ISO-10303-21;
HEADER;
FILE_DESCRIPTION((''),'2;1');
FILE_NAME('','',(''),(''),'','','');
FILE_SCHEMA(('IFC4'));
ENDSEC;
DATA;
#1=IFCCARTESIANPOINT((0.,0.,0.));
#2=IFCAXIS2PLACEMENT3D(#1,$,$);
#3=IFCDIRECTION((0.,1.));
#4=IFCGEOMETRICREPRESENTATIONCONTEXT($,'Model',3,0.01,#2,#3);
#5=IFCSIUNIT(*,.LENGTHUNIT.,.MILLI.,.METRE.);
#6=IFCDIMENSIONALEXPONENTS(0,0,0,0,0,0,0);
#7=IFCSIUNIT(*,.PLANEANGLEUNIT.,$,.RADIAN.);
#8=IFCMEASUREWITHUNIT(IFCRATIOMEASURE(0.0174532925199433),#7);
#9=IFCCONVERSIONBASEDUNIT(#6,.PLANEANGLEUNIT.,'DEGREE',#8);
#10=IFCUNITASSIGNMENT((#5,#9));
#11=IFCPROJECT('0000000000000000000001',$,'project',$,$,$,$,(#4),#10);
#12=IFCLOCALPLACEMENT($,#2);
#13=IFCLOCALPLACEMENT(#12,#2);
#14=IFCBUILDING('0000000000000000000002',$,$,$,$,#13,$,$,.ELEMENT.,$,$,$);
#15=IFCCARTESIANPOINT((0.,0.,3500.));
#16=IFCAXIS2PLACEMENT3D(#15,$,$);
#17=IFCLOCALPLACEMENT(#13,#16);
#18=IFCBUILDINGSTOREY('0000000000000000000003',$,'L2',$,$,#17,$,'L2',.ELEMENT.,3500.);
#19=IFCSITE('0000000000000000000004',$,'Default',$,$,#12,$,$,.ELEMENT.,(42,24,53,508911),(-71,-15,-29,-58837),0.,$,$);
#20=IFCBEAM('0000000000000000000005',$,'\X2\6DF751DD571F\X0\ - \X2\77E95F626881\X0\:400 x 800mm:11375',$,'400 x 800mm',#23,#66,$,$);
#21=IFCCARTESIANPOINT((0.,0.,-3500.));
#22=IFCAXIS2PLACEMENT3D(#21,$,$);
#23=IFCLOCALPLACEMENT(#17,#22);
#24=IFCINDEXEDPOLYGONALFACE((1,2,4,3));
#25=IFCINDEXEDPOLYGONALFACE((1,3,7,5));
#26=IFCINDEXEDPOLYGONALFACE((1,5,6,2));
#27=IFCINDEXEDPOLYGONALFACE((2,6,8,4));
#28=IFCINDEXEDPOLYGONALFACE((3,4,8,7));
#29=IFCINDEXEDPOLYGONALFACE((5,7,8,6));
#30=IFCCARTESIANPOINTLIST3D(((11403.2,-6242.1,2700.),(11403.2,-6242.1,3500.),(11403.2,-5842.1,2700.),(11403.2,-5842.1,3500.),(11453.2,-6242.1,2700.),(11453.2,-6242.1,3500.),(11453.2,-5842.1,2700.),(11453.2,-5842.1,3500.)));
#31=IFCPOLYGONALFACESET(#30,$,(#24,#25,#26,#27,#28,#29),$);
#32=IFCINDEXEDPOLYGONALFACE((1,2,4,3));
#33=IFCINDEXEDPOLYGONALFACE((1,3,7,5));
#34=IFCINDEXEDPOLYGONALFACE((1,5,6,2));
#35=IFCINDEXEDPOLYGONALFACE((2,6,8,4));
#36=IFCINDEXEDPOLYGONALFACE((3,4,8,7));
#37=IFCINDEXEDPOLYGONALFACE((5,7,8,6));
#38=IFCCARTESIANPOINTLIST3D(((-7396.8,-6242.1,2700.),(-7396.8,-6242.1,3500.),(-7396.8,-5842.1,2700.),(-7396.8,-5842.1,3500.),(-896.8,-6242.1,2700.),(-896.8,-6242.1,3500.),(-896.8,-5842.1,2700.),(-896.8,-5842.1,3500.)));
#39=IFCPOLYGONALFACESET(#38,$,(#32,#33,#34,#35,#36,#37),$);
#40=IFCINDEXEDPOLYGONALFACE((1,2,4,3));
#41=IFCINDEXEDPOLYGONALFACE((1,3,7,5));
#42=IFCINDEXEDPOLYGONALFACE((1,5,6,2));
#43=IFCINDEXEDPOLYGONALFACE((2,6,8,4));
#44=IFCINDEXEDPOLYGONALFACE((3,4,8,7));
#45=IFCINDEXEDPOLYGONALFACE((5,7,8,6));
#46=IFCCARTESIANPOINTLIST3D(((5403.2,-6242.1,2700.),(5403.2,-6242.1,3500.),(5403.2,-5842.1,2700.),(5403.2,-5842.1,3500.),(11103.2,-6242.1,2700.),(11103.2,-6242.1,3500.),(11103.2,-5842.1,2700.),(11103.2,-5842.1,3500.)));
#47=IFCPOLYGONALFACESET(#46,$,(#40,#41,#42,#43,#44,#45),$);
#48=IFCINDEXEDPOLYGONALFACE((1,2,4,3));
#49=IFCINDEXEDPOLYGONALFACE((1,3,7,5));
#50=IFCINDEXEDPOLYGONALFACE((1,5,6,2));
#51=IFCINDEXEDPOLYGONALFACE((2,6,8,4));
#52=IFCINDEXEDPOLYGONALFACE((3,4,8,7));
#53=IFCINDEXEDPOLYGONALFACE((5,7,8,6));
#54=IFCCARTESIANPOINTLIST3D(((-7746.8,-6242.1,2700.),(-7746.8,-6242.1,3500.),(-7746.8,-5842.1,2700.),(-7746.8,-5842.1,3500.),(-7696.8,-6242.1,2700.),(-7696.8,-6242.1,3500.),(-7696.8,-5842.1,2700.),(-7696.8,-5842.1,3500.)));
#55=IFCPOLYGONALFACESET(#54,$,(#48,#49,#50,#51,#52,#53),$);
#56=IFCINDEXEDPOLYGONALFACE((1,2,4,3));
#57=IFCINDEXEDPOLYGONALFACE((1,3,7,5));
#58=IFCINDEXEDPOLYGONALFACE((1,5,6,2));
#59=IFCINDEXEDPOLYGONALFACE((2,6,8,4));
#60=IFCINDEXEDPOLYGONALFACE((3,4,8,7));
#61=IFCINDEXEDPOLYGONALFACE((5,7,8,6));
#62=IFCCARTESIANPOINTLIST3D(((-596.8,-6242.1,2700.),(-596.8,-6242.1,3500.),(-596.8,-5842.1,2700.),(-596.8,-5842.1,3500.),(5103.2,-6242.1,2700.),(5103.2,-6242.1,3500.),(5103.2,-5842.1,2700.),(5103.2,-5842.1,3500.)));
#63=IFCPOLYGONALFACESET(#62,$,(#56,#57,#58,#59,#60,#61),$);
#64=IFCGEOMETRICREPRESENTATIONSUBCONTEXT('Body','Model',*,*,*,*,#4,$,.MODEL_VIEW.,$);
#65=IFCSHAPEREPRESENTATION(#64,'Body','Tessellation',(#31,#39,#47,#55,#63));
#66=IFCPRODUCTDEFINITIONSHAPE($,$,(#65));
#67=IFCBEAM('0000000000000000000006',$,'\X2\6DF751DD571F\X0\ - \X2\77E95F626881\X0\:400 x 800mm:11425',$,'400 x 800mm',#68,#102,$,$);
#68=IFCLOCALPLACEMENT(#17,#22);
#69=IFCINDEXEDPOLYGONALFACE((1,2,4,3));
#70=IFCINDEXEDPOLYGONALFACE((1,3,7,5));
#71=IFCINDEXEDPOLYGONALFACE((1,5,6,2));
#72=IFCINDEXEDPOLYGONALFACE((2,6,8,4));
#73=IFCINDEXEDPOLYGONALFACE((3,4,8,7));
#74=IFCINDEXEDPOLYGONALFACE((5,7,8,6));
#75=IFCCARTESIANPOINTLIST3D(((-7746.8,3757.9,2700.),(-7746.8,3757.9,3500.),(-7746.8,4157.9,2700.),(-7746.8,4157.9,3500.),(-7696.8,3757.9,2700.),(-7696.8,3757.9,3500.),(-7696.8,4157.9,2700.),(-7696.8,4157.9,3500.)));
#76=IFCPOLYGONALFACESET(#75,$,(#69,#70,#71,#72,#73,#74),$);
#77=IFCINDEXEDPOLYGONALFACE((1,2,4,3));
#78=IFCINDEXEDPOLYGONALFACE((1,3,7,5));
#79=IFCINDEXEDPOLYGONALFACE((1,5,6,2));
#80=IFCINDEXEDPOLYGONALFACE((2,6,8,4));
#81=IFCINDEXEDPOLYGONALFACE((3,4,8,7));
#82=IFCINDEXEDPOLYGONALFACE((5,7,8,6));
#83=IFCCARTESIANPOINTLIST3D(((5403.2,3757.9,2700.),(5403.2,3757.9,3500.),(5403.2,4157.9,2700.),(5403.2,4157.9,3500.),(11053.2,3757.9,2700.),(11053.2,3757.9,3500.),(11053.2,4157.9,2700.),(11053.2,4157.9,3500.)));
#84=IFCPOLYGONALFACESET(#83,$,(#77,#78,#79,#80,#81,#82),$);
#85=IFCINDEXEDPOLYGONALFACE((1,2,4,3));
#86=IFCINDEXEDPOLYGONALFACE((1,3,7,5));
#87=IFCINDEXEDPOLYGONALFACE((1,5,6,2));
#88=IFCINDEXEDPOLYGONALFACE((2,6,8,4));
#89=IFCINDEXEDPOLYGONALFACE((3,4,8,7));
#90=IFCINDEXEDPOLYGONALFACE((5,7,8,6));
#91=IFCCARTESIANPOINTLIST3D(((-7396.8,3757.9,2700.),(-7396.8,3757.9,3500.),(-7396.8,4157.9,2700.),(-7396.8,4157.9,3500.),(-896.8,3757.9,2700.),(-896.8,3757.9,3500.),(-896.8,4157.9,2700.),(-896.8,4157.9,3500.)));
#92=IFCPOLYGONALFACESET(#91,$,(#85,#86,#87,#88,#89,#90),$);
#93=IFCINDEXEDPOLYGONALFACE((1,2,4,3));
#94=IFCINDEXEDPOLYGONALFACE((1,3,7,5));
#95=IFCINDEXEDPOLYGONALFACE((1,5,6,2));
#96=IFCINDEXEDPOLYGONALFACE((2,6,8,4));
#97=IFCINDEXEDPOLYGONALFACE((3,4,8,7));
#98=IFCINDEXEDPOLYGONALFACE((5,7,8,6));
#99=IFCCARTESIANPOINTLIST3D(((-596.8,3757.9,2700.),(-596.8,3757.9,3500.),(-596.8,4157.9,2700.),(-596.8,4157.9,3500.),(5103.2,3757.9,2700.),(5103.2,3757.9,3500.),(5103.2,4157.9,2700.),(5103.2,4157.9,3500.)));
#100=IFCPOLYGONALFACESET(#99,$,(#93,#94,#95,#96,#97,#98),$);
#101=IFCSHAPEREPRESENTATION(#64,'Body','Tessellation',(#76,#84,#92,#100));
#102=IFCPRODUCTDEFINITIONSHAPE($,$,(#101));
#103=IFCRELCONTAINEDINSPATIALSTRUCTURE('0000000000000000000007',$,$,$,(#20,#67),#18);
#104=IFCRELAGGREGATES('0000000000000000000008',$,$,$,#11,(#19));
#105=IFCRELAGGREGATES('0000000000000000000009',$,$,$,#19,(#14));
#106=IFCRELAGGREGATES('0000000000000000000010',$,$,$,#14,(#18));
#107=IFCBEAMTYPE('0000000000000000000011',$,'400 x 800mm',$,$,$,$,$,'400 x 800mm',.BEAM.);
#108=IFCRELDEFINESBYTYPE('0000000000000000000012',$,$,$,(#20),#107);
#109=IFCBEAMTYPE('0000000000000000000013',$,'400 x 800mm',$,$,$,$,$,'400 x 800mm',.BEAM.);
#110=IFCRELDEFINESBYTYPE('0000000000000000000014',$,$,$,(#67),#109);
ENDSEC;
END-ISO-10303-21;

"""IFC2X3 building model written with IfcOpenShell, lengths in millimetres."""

from ifc_helpers import new_model, entity, si_unit, converted_unit, direction, frame, frame_2d, origin, place, context, subcontext, project, spatial, rectangle, extrude, source, transform, mapped, type_object, type_shapes, element, save


model = new_model("IFC2X3")

# Units and contexts
model_context = context("Model", 3, precision=0.01, world=origin(), true_north=direction((0.0, 1.0)))
body_context = subcontext(model_context, "Body", "Model", "MODEL_VIEW")
ifc_project = project(units=[si_unit("LENGTHUNIT", "METRE", prefix="MILLI"), converted_unit("PLANEANGLEUNIT", "DEGREE", entity("IfcRatioMeasure", 0.0174532925199433), si_unit("PLANEANGLEUNIT", "RADIAN"), dimensions=[0, 0, 0, 0, 0, 0, 0])], contexts=[model_context])

# Site, building, storey
site_placement = place(None, origin())
site = spatial("IfcSite", under=ifc_project, at=site_placement, Name="Default", CompositionType="ELEMENT", RefLatitude=(42, 24, 53, 508911), RefLongitude=(-71, -15, -29, -58837), RefElevation=0.0)
building_placement = place(site_placement, origin())
building = spatial("IfcBuilding", under=site, at=building_placement, CompositionType="ELEMENT")
storey_placement = place(building_placement, frame((0.0, 0.0, 3500.0)))
storey = spatial("IfcBuildingStorey", under=building, at=storey_placement, Name="L2", LongName="L2", CompositionType="ELEMENT", Elevation=3500.0)

# Beams
beam_type_1 = type_object("IfcBeamType", Name="400 x 800mm", ElementType="400 x 800mm", PredefinedType="BEAM")
shared_shape_1 = source(origin(), body_context, "Body", "SweptSolid", [
    extrude(rectangle(XDim=50.0, YDim=400.0, at=frame_2d((0.0, 0.0), x_axis=(1.0, 0.0))), frame((11428.2, -6042.1, 2700.0), z_axis=(0.0, 0.0, 1.0), x_axis=(-1.0, 0.0, 0.0)), (0.0, 0.0, 1.0), 800.0),
    extrude(rectangle(XDim=6500.0, YDim=400.0, at=frame_2d((640.0, -40.0), x_axis=(1.0, 0.0))), frame((-4786.8, -6002.1, 2700.0)), (0.0, 0.0, 1.0), 800.0),
    extrude(rectangle(XDim=5700.0, YDim=400.0, at=frame_2d((560.0, 40.0), x_axis=(1.0, 0.0))), frame((8813.2, -6002.1, 2700.0), z_axis=(0.0, 0.0, 1.0), x_axis=(-1.0, 0.0, 0.0)), (0.0, 0.0, 1.0), 800.0),
    extrude(rectangle(XDim=50.0, YDim=400.0, at=frame_2d((0.0, 0.0), x_axis=(1.0, 0.0))), frame((-7721.8, -6042.1, 2700.0)), (0.0, 0.0, 1.0), 800.0),
    extrude(rectangle(XDim=5700.0, YDim=400.0, at=frame_2d((0.0, 0.0), x_axis=(1.0, 0.0))), frame((2253.2, -6042.1, 2700.0), z_axis=(0.0, 0.0, 1.0), x_axis=(-1.0, 0.0, 0.0)), (0.0, 0.0, 1.0), 800.0),
])
type_shapes(beam_type_1, [shared_shape_1])
beam_1_placement = place(storey_placement, frame((0.0, 0.0, -3500.0)))
element("IfcBeam", 1, at=beam_1_placement, inside=storey, type_object=beam_type_1, Name="混凝土 - 矩形梁:400 x 800mm:11375", ObjectType="400 x 800mm", context=body_context, shape_type="MappedRepresentation", body=[
    mapped(shared_shape_1, transform((0.0, 0.0, 0.0), scale=1.0)),
])
beam_type_2 = type_object("IfcBeamType", Name="400 x 800mm", ElementType="400 x 800mm", PredefinedType="BEAM")
shared_shape_2 = source(origin(), body_context, "Body", "SweptSolid", [
    extrude(rectangle(XDim=50.0, YDim=400.0, at=frame_2d((0.0, 0.0), x_axis=(1.0, 0.0))), frame((-7721.8, 3957.9, 2700.0)), (0.0, 0.0, 1.0), 800.0),
    extrude(rectangle(XDim=5650.0, YDim=400.0, at=frame_2d((0.0, 0.0), x_axis=(1.0, 0.0))), frame((8228.2, 3957.9, 2700.0), z_axis=(0.0, 0.0, 1.0), x_axis=(-1.0, 0.0, 0.0)), (0.0, 0.0, 1.0), 800.0),
    extrude(rectangle(XDim=6500.0, YDim=400.0, at=frame_2d((640.0, 40.0), x_axis=(1.0, 0.0))), frame((-4786.8, 3917.9, 2700.0)), (0.0, 0.0, 1.0), 800.0),
    extrude(rectangle(XDim=5700.0, YDim=400.0, at=frame_2d((0.0, 0.0), x_axis=(1.0, 0.0))), frame((2253.2, 3957.9, 2700.0), z_axis=(0.0, 0.0, 1.0), x_axis=(-1.0, 0.0, 0.0)), (0.0, 0.0, 1.0), 800.0),
])
type_shapes(beam_type_2, [shared_shape_2])
beam_2_placement = place(storey_placement, frame((0.0, 0.0, -3500.0)))
element("IfcBeam", 2, at=beam_2_placement, inside=storey, type_object=beam_type_2, Name="混凝土 - 矩形梁:400 x 800mm:11425", ObjectType="400 x 800mm", context=body_context, shape_type="MappedRepresentation", body=[
    mapped(shared_shape_2, transform((0.0, 0.0, 0.0), scale=1.0)),
])

save(model, "model.ifc")
